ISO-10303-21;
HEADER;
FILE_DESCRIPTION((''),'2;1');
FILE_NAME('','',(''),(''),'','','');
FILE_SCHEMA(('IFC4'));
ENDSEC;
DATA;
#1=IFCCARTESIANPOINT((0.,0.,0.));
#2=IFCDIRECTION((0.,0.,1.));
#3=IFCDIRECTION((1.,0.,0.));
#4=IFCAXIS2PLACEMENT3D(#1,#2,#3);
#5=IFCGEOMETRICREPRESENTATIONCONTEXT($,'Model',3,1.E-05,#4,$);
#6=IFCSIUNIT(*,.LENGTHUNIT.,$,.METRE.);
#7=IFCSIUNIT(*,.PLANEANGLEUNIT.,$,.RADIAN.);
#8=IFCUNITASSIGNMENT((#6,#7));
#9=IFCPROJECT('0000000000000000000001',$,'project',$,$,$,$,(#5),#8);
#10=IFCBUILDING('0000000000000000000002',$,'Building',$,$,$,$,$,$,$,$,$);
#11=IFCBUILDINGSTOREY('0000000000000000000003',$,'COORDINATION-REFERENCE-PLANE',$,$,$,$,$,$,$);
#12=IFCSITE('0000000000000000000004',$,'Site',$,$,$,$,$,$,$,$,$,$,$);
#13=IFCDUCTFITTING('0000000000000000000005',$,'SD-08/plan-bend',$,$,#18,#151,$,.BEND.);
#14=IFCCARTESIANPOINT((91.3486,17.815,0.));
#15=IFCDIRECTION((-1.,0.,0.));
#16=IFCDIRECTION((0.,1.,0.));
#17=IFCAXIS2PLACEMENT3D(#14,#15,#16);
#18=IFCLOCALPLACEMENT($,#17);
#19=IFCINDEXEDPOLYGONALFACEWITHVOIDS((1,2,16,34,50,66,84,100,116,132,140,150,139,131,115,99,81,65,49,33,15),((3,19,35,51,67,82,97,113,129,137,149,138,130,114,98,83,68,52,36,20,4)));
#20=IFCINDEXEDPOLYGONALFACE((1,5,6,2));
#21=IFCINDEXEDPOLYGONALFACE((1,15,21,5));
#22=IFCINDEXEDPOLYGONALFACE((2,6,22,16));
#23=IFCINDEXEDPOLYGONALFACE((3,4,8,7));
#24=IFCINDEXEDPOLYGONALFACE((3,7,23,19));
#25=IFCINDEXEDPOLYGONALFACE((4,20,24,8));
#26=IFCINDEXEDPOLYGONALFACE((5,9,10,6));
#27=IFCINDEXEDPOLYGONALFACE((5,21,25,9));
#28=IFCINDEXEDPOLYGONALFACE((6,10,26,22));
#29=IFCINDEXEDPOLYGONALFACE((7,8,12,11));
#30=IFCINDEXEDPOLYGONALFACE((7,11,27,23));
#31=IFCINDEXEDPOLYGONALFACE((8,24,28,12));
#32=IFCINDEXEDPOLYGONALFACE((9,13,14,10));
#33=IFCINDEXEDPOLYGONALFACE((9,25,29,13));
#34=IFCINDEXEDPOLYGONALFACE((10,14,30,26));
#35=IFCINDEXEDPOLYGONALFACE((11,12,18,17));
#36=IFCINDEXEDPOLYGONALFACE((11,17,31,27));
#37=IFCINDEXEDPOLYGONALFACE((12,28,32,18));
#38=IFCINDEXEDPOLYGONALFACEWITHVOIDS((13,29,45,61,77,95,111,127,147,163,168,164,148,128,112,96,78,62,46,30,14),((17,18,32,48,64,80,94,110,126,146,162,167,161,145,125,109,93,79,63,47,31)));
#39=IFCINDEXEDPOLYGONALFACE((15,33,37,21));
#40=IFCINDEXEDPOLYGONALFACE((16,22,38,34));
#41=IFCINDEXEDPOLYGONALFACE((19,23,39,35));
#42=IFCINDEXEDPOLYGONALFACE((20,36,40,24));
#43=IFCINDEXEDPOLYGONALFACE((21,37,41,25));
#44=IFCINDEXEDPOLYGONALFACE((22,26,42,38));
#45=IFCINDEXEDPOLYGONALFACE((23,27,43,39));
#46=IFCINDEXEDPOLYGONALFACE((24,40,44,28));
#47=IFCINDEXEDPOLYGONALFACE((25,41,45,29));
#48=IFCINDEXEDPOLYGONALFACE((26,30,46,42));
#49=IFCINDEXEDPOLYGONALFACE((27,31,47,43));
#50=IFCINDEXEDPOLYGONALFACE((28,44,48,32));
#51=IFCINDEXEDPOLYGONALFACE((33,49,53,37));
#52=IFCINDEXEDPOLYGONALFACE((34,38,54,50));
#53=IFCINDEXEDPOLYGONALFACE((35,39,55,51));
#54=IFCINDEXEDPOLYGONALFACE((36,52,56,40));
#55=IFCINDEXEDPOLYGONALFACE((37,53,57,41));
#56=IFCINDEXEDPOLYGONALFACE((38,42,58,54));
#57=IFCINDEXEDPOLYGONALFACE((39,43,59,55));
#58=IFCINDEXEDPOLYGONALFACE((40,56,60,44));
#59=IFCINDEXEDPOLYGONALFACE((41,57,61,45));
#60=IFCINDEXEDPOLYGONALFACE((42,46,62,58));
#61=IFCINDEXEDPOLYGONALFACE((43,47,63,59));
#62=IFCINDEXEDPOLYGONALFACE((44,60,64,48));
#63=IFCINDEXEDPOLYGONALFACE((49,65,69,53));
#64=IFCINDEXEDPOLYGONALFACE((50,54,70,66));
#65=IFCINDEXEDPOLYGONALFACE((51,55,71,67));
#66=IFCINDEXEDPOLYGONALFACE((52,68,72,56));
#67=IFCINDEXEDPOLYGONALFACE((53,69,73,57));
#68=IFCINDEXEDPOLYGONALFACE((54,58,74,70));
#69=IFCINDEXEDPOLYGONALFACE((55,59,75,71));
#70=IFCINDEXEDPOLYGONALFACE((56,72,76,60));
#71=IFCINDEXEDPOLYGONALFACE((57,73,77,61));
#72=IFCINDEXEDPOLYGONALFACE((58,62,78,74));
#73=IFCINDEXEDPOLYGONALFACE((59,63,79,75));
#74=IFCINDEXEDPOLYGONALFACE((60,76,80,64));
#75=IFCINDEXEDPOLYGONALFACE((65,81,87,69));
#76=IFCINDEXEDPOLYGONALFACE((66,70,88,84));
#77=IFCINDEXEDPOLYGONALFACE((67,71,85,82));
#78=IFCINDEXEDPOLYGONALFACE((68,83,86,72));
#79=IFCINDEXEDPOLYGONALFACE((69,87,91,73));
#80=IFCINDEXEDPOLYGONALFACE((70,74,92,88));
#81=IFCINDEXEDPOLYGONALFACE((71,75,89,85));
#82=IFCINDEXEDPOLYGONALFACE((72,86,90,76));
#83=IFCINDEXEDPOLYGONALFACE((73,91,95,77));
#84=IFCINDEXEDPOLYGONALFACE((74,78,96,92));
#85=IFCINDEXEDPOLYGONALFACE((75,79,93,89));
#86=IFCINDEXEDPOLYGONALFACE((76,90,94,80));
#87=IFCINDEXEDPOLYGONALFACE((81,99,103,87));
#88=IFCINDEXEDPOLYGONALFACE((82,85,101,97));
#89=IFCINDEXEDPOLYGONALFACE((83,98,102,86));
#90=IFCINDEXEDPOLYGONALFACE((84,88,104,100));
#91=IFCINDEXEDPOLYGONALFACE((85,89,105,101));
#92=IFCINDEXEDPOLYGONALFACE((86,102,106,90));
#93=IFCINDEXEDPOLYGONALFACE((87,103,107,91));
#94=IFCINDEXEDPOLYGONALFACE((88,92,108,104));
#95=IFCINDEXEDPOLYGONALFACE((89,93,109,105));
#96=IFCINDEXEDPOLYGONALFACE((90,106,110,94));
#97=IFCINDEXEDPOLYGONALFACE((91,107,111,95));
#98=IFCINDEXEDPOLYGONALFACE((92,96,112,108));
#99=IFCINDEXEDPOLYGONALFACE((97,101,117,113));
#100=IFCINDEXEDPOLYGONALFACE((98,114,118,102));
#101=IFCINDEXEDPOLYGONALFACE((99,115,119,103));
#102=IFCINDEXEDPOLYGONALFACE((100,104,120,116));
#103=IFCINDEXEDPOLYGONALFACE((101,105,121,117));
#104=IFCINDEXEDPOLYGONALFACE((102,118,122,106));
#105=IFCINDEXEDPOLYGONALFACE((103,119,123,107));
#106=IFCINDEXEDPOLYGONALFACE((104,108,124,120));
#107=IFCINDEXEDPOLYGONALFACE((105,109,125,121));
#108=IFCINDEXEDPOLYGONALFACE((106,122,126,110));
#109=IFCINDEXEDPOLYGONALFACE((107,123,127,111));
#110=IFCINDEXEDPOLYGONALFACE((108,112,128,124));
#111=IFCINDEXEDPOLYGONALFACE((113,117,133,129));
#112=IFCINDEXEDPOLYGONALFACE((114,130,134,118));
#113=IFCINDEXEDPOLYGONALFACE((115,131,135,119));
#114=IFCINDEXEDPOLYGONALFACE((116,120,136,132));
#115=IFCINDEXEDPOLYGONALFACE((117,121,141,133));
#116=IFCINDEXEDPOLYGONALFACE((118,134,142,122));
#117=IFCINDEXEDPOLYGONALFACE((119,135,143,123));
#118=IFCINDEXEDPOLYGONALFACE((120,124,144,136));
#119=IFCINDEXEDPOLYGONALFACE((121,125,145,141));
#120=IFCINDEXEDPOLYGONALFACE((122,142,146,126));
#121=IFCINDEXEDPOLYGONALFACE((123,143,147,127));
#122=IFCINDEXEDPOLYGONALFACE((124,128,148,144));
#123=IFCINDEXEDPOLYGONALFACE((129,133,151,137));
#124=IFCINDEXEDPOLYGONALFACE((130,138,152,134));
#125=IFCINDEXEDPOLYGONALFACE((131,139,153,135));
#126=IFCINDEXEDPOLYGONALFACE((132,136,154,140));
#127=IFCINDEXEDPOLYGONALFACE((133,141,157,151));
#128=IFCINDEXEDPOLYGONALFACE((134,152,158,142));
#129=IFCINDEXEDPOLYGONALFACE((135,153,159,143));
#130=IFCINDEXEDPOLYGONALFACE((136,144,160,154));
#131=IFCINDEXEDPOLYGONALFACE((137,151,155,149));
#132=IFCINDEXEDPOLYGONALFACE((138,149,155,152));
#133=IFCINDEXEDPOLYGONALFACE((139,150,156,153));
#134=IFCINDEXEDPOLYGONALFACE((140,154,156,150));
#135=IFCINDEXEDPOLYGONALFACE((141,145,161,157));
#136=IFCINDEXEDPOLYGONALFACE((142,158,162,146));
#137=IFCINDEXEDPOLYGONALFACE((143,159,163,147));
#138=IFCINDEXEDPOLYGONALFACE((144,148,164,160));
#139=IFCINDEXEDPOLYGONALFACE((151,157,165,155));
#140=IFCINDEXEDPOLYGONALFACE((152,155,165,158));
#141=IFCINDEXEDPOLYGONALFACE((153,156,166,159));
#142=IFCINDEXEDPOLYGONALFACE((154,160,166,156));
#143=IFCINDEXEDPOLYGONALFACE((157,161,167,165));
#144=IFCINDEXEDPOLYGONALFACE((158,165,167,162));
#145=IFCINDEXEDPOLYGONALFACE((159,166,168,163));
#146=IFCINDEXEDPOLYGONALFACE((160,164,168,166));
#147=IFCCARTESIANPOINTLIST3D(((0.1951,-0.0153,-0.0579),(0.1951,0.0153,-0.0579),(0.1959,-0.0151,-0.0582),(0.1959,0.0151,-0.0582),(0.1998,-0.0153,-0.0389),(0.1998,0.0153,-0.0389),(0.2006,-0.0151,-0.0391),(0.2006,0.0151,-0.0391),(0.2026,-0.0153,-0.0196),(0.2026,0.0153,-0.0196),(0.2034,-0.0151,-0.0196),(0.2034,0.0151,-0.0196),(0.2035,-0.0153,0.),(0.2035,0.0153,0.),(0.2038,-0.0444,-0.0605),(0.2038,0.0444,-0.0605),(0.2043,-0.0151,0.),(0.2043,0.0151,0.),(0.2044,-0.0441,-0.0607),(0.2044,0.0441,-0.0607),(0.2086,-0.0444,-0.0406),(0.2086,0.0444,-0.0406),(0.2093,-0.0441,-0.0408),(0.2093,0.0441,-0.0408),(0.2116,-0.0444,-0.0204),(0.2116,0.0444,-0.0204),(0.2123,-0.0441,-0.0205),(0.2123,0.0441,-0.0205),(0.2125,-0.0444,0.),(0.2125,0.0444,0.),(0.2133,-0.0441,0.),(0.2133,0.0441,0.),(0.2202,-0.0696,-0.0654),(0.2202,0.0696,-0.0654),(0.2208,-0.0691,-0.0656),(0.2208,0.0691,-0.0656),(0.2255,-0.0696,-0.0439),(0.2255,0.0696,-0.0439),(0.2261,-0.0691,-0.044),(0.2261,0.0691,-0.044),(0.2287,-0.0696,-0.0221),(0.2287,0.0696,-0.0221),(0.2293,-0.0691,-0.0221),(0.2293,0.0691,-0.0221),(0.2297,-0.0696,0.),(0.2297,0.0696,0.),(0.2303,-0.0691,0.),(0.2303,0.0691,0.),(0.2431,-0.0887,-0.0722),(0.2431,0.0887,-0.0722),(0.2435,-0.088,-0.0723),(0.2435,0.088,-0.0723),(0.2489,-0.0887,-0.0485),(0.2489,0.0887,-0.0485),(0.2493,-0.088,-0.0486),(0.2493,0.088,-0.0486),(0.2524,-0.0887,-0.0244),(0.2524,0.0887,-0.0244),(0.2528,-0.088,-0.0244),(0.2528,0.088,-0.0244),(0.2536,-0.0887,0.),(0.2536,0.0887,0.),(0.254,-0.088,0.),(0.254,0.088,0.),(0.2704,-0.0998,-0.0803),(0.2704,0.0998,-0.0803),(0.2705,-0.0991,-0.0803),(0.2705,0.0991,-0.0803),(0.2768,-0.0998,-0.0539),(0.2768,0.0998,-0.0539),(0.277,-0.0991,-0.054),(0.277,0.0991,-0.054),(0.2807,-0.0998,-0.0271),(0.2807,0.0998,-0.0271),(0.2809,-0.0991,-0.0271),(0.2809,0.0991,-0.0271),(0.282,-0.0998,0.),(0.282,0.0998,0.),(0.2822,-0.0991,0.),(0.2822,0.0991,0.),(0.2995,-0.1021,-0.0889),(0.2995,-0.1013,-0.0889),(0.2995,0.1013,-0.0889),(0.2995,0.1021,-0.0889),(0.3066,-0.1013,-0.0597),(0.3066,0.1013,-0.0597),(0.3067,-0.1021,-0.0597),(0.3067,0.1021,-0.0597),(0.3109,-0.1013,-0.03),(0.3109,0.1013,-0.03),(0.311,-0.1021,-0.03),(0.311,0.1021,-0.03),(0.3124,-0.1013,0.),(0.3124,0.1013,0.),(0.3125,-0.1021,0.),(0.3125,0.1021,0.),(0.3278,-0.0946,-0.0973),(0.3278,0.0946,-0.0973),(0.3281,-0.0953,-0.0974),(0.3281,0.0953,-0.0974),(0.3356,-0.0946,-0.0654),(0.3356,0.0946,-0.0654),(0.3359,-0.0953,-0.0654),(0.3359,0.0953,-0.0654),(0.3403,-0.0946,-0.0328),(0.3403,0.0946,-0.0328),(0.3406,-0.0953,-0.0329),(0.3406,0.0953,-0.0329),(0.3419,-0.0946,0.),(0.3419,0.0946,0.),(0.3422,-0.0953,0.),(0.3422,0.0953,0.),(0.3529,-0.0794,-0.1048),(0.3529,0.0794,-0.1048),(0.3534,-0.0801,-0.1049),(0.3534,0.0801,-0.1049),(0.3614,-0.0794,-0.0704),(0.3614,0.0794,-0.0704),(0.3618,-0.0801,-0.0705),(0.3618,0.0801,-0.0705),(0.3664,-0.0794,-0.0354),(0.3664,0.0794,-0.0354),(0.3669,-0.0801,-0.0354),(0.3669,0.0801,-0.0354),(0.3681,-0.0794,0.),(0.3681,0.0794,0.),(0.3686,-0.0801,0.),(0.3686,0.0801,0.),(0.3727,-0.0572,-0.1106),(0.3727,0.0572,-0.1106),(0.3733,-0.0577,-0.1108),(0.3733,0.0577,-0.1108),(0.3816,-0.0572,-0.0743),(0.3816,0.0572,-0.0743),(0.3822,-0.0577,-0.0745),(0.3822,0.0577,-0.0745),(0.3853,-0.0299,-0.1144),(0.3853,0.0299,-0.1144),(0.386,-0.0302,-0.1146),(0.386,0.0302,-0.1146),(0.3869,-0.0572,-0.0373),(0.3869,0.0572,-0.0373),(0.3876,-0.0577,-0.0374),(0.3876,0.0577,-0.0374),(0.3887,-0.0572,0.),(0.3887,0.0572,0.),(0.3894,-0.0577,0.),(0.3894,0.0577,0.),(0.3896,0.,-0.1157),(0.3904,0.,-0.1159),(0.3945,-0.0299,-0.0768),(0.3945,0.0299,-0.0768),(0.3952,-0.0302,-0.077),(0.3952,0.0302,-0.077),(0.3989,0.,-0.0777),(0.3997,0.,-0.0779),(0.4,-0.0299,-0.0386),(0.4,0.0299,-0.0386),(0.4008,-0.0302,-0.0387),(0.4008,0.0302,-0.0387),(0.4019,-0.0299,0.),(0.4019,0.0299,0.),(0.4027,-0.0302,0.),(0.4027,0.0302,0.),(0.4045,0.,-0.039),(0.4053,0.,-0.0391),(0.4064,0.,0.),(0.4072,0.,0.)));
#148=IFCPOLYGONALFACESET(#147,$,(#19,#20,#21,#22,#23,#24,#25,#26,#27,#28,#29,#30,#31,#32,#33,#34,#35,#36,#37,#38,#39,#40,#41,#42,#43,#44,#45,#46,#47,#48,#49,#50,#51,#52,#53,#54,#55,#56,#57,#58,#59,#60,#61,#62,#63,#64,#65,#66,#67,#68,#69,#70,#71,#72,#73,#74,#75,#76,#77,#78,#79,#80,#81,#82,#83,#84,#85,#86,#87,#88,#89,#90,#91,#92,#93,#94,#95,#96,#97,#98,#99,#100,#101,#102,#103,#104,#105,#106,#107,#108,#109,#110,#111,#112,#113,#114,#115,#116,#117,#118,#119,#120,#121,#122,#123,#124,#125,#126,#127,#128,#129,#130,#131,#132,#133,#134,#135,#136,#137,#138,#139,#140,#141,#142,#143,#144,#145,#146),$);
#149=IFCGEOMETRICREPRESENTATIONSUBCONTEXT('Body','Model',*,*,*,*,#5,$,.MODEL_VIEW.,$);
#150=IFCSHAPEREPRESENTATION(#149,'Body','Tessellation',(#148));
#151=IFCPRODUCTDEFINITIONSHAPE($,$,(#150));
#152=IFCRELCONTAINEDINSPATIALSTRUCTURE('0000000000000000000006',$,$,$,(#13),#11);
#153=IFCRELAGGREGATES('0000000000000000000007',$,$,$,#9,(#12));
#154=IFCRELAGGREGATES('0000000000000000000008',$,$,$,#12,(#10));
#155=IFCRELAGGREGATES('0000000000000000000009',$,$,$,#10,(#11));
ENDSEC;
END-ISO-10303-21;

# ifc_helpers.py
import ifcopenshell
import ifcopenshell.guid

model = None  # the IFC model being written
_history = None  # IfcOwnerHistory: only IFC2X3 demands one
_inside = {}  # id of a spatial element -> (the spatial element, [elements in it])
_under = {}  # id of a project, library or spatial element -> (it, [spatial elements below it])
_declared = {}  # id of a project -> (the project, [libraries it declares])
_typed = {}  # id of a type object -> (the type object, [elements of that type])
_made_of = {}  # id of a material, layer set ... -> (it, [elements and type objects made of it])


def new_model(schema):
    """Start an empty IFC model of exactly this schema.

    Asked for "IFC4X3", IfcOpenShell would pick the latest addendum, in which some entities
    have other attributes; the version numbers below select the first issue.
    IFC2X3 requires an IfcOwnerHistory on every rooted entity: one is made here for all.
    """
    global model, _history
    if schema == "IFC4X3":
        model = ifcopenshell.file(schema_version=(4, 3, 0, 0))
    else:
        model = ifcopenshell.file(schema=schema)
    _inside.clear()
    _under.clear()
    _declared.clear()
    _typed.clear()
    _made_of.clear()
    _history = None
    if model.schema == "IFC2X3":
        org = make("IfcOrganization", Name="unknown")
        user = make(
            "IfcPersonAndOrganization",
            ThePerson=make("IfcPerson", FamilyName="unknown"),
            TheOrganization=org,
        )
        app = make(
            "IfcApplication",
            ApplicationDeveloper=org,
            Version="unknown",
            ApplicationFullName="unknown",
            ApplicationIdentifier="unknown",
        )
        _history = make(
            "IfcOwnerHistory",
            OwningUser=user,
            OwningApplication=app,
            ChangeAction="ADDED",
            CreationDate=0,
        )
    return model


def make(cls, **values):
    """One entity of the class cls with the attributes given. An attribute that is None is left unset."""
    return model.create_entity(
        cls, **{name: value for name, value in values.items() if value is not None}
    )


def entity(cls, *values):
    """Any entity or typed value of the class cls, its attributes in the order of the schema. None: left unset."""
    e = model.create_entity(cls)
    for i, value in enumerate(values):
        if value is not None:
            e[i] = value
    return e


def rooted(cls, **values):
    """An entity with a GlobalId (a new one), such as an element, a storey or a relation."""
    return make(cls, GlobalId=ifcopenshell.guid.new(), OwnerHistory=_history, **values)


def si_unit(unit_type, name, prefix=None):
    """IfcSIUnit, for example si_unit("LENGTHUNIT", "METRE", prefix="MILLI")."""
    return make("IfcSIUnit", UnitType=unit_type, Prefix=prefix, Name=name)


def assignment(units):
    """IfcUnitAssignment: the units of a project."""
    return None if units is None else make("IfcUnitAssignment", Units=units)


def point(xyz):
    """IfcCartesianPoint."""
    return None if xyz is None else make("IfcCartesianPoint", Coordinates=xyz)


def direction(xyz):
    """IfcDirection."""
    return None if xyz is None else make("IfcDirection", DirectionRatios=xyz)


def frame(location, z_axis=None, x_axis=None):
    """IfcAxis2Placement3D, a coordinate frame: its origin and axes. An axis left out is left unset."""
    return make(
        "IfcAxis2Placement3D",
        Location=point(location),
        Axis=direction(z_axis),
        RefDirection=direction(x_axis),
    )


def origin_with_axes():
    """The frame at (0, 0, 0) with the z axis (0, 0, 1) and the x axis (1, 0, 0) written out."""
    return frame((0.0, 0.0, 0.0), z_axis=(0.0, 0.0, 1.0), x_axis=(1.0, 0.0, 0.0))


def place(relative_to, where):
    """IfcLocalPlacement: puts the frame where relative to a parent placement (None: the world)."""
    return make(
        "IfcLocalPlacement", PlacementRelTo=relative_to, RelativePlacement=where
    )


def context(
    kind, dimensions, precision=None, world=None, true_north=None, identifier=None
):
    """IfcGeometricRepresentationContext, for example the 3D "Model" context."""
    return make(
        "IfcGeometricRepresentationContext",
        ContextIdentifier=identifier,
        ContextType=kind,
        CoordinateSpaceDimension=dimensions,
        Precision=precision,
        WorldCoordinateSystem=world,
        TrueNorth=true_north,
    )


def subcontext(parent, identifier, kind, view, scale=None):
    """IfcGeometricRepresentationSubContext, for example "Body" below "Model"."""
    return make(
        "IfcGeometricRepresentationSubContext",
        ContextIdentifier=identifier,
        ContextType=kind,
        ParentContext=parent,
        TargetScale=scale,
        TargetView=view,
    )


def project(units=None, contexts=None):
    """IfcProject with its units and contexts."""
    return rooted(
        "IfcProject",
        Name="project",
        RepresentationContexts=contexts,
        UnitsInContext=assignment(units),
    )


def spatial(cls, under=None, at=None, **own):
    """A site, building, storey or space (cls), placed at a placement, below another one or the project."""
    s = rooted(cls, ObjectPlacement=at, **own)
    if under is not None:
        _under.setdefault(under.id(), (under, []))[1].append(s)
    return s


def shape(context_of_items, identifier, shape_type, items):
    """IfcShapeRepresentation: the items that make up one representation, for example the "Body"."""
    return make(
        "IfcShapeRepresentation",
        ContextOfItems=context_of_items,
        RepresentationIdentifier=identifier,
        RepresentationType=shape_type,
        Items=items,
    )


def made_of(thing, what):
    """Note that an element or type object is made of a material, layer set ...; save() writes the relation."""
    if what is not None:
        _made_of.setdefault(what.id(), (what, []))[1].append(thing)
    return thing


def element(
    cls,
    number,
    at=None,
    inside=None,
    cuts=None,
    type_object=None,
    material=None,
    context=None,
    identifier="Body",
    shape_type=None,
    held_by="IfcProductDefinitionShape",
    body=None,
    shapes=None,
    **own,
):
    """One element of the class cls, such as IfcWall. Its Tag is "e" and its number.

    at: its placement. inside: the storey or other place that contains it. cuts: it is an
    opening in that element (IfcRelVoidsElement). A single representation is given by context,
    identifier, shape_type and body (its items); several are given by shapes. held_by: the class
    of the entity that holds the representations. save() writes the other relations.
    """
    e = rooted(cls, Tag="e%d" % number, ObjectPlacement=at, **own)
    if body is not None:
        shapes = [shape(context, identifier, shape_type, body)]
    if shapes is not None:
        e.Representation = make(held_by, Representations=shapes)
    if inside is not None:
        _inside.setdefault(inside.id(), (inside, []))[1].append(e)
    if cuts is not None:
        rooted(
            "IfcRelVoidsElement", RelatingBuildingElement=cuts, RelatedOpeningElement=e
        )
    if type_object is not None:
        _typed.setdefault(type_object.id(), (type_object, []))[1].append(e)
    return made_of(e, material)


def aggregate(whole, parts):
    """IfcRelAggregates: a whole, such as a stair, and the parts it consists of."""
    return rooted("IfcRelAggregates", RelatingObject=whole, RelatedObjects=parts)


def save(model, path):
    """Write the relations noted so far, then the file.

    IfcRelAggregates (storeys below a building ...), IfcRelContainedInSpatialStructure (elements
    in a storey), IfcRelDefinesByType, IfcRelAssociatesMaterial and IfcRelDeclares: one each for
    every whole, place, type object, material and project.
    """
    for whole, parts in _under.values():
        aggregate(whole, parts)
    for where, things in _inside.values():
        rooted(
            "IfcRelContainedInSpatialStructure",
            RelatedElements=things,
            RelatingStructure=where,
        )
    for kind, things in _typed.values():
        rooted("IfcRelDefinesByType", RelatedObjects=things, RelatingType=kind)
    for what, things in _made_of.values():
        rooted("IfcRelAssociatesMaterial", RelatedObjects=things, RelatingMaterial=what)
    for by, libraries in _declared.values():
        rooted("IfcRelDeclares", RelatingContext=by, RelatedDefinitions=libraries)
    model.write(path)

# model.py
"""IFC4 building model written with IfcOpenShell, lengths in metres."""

from ifc_helpers import new_model, entity, si_unit, frame, origin_with_axes, place, context, subcontext, project, spatial, element, save


model = new_model("IFC4")

# Units and contexts
model_context_1 = context("Model", 3, precision=1e-05, world=origin_with_axes())
body_context_1 = subcontext(model_context_1, "Body", "Model", "MODEL_VIEW")
ifc_project = project(units=[si_unit("LENGTHUNIT", "METRE"), si_unit("PLANEANGLEUNIT", "RADIAN")], contexts=[model_context_1])

# Site, building, storey
site = spatial("IfcSite", under=ifc_project, Name="Site")
building = spatial("IfcBuilding", under=site, Name="Building")
storey = spatial("IfcBuildingStorey", under=building, Name="COORDINATION-REFERENCE-PLANE")

# Duct fitting
duct_fitting_1_placement = place(None, frame((91.3486, 17.815, 0.0), z_axis=(-1.0, 0.0, 0.0), x_axis=(0.0, 1.0, 0.0)))
element("IfcDuctFitting", 1, at=duct_fitting_1_placement, inside=storey, Name="SD-08/plan-bend", PredefinedType="BEND", context=body_context_1, shape_type="SweptSolid", body=[
    entity("IfcRevolvedAreaSolid", entity("IfcCircleHollowProfileDef", "AREA", None, entity("IfcAxis2Placement2D", entity("IfcCartesianPoint", [0.3048, 0.0])), 0.1024, 0.0008), entity("IfcAxis2Placement3D", entity("IfcCartesianPoint", [0.0, 0.0, 0.0]), entity("IfcDirection", [0.0, 0.0, 1.0]), entity("IfcDirection", [1.0, 0.0, 0.0])), entity("IfcAxis1Placement", entity("IfcCartesianPoint", [0.0, 0.0, 0.0]), entity("IfcDirection", [0.0, 1.0, 0.0])), 0.288593),
])

save(model, "model.ifc")
